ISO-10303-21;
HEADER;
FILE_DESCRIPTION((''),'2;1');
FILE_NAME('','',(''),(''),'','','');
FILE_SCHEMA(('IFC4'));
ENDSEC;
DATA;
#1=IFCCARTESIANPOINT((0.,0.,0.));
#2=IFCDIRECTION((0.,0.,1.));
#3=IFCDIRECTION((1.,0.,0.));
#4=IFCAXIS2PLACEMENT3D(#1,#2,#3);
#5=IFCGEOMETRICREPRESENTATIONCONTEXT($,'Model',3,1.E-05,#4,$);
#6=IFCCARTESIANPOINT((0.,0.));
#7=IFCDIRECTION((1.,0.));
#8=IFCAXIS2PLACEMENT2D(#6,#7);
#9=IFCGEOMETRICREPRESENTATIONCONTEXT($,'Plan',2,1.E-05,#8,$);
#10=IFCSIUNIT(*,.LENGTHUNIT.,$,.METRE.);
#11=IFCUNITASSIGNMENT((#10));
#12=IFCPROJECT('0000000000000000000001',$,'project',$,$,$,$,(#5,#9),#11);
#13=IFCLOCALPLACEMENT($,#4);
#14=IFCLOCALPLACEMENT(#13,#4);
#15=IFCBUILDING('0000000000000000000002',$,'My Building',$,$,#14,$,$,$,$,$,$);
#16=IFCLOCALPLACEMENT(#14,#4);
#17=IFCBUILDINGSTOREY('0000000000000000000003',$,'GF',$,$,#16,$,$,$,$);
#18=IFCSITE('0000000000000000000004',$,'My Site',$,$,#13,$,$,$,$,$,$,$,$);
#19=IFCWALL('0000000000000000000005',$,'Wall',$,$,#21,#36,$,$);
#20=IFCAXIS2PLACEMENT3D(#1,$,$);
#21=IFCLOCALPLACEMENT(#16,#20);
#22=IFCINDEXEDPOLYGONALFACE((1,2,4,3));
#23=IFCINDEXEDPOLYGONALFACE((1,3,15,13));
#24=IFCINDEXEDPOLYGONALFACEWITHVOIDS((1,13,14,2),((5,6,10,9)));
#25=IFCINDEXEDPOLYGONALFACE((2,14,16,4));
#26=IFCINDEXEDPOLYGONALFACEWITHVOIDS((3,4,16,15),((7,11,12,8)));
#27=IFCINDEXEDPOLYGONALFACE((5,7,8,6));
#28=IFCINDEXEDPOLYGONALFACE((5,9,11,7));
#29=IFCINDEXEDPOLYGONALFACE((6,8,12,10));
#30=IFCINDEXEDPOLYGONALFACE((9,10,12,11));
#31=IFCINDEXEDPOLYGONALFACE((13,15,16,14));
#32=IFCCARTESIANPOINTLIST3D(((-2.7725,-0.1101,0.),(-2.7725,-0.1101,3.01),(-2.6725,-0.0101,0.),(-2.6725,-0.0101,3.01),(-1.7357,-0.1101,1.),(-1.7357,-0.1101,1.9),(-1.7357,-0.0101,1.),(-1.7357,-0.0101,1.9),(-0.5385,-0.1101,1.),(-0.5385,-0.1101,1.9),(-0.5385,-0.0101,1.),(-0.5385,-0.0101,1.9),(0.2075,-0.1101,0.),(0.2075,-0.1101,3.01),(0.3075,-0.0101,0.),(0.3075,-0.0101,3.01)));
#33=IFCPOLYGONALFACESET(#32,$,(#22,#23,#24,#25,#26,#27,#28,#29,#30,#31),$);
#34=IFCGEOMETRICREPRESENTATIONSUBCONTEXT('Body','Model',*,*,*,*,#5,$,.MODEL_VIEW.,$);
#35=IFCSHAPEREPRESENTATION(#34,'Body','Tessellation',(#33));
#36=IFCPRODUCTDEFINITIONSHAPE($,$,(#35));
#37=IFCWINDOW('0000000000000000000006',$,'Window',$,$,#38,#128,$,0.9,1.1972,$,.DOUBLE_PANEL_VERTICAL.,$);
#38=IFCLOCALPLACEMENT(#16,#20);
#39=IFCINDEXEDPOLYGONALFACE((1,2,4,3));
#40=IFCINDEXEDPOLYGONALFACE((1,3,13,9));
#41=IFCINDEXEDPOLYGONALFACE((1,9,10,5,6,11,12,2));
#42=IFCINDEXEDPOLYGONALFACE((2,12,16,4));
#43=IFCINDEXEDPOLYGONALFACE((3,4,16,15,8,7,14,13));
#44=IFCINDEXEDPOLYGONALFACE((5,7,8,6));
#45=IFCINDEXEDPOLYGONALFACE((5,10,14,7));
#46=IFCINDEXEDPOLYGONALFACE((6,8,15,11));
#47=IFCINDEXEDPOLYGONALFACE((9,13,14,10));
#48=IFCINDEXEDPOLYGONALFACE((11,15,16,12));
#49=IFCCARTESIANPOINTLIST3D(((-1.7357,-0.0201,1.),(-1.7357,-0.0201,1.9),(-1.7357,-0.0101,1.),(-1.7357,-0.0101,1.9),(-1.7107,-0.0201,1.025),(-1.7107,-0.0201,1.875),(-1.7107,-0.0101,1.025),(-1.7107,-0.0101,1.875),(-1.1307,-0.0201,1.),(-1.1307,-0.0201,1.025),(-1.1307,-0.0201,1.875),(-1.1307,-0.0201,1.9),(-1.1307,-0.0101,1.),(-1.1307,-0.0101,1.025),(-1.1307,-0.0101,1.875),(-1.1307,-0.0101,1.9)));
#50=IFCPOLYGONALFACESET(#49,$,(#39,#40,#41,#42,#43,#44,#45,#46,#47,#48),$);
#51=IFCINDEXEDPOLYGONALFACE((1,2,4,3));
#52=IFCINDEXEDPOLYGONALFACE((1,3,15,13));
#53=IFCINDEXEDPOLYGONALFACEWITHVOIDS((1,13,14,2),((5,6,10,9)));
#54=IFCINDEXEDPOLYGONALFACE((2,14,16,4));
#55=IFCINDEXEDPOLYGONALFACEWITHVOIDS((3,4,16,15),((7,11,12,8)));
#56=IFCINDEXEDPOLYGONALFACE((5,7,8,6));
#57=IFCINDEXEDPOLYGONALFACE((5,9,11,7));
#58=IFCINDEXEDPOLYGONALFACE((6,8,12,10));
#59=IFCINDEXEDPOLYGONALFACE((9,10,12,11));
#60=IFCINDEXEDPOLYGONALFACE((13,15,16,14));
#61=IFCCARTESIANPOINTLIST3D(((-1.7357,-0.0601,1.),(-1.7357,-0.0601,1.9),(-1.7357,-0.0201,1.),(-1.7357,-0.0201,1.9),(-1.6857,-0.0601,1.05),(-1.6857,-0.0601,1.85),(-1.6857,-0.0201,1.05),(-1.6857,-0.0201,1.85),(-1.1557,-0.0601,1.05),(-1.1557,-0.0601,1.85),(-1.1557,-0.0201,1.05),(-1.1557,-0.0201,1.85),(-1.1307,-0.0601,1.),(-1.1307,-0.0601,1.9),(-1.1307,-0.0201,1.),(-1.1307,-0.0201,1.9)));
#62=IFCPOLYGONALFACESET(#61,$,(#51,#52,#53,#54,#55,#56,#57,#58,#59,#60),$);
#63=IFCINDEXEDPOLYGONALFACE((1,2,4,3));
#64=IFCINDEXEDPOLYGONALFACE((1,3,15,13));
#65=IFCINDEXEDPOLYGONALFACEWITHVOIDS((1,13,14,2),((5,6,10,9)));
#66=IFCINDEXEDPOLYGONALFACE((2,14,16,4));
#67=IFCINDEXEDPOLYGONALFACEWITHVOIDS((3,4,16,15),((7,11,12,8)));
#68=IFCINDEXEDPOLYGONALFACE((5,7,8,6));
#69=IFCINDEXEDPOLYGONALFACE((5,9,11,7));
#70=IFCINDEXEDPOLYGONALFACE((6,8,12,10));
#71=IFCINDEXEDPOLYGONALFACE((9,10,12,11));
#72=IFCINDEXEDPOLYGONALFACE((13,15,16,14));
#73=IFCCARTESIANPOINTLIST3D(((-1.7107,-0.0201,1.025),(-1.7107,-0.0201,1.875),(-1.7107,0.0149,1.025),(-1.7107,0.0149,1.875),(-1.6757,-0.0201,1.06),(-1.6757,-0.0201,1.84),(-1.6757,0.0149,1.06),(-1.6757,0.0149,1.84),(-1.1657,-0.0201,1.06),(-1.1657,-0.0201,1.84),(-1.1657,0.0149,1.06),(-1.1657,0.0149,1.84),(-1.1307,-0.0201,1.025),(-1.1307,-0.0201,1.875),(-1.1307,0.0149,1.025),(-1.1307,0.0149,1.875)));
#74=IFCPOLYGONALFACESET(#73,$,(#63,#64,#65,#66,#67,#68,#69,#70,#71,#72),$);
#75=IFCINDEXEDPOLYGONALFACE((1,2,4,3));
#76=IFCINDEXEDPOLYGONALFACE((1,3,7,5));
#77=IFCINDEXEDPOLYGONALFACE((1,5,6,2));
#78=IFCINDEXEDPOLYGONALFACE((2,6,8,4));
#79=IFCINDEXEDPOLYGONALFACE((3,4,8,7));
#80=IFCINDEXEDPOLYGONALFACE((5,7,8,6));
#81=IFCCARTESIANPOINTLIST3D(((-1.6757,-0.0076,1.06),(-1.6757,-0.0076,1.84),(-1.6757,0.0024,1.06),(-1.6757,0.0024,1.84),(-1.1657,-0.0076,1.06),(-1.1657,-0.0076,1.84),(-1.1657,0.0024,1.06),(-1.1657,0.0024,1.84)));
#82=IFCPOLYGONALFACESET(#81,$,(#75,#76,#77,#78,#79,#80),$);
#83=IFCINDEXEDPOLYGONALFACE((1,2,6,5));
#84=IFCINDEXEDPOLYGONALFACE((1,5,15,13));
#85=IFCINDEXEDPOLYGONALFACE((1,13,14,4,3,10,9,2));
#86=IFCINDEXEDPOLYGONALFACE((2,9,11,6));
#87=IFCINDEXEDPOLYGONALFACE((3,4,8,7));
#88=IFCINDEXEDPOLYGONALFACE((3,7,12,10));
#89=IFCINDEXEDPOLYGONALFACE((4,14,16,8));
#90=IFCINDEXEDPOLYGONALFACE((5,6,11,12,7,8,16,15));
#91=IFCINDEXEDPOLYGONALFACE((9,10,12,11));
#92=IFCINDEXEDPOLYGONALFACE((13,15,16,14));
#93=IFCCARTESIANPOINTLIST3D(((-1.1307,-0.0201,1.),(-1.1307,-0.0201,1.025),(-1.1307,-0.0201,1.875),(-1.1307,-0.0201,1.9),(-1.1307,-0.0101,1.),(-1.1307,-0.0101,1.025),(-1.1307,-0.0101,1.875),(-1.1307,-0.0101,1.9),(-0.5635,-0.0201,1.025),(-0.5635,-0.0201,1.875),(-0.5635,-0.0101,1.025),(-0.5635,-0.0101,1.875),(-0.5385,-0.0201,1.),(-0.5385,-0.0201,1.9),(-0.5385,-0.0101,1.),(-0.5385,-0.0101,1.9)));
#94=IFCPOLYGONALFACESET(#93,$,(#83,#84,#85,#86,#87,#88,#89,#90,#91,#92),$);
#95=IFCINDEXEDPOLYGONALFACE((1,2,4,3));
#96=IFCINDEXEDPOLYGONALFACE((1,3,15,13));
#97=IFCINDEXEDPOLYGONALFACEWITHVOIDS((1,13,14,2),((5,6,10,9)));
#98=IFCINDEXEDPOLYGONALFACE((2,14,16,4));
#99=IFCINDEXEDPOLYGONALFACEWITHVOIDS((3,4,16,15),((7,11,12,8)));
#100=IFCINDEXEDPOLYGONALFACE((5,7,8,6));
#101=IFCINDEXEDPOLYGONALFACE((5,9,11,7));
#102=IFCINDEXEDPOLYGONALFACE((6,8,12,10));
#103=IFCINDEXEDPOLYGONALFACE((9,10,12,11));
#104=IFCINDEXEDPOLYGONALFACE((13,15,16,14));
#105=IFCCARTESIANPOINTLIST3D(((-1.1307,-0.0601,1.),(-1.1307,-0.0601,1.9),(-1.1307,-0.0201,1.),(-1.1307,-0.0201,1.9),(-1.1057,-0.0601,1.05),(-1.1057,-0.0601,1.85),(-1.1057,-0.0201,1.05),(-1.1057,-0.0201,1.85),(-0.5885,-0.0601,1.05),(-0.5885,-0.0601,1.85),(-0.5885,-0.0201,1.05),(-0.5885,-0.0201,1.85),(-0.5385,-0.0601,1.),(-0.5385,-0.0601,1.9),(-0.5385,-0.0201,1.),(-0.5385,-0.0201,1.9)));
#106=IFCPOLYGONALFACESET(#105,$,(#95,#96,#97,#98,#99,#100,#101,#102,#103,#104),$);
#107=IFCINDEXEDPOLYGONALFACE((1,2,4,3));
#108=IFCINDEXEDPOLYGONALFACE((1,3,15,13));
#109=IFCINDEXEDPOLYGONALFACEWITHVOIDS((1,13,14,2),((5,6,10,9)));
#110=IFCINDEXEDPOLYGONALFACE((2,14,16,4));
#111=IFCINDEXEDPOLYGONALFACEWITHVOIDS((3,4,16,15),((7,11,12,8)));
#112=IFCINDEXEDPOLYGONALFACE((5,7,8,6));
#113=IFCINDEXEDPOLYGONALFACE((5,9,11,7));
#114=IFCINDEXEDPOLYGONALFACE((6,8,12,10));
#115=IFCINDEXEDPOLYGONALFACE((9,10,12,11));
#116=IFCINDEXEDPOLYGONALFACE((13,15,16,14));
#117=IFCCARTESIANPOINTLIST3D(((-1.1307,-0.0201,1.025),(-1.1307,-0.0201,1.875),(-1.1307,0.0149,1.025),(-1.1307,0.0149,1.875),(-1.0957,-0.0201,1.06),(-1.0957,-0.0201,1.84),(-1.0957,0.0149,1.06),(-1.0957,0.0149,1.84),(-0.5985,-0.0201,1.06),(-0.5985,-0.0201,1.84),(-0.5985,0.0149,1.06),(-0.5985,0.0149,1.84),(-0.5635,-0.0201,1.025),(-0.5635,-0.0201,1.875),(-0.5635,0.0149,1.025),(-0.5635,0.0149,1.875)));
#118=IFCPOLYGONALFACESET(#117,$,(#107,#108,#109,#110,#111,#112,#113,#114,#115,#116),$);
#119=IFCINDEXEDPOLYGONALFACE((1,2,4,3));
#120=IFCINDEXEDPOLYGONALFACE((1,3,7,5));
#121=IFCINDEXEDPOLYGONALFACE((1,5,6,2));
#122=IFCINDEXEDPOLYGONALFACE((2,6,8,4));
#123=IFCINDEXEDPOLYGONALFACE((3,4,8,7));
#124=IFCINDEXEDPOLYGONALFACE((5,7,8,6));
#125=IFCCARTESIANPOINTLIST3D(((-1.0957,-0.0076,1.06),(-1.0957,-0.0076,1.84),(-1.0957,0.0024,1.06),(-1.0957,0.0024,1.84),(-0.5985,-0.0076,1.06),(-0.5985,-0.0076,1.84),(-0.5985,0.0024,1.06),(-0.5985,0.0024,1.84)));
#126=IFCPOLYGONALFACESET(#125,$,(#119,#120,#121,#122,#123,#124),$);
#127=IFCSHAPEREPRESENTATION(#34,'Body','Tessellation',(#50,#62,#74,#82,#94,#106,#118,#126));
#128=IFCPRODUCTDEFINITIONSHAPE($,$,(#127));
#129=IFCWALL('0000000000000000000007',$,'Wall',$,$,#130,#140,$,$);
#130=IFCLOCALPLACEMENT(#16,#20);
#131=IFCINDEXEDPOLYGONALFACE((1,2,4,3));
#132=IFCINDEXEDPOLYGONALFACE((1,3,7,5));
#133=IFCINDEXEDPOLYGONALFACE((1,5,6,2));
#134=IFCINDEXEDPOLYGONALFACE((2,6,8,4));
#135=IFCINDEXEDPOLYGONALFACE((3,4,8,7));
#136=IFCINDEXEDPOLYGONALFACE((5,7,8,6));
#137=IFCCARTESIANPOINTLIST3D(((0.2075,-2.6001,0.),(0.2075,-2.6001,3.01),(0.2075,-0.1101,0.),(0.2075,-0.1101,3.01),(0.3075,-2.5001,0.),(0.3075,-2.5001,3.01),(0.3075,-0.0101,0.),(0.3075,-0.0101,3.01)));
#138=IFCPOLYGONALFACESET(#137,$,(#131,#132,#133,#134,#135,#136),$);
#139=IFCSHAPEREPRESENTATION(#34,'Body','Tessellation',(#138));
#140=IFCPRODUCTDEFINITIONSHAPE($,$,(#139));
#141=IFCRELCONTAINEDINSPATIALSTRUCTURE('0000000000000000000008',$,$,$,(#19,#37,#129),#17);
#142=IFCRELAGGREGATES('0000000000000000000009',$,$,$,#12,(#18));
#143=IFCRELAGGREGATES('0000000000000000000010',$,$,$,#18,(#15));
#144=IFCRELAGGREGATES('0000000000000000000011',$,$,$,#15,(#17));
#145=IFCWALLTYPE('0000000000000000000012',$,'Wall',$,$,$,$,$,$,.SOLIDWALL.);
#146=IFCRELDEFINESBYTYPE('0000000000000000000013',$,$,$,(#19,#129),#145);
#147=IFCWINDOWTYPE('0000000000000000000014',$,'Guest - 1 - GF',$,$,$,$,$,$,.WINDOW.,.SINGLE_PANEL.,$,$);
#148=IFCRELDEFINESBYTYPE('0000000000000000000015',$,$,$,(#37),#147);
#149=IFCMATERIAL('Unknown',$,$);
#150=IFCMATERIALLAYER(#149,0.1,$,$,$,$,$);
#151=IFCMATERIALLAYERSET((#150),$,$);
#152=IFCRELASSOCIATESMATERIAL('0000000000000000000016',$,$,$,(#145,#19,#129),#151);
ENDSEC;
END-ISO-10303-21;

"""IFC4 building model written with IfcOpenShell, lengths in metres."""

from ifc_helpers import new_model, entity, si_unit, frame, origin_with_axes, origin_2d_with_axis, place, context, subcontext, project, spatial, line, indexed_curve, outline, extrude, shape, source, transform, mapped, material, layer, layer_set, layer_usage, type_object, type_shapes, element, fill, save


model = new_model("IFC4")

# Units and contexts
model_context = context("Model", 3, precision=1e-05, world=origin_with_axes())
plan_context = context("Plan", 2, precision=1e-05, world=origin_2d_with_axis())
body_context_1 = subcontext(model_context, "Body", "Model", "MODEL_VIEW")
body_context_2 = subcontext(plan_context, "Body", "Plan", "PLAN_VIEW")
ifc_project = project(units=[si_unit("LENGTHUNIT", "METRE")], contexts=[model_context, plan_context])

# Site, building, storey
site_placement = place(None, origin_with_axes())
site = spatial("IfcSite", under=ifc_project, at=site_placement, Name="My Site")
building_placement = place(site_placement, origin_with_axes())
building = spatial("IfcBuilding", under=site, at=building_placement, Name="My Building")
storey_placement = place(building_placement, origin_with_axes())
storey = spatial("IfcBuildingStorey", under=building, at=storey_placement, Name="GF")

# Shared definitions
ifc_material = material(Name="Unknown")

# Shared definitions
ifc_layer_1 = layer(ifc_material, 0.1)
ifc_layer_set_1 = layer_set([ifc_layer_1])
wall_type = type_object("IfcWallType", Name="Wall", PredefinedType="SOLIDWALL", material=ifc_layer_set_1)

# Wall, opening, window
ifc_layer_usage_1 = layer_usage(ifc_layer_set_1, "AXIS2", "POSITIVE", 0.0)
wall_1_placement = place(storey_placement, frame((-2.7725, -0.1101, 0.0), z_axis=(0.0, 0.0, 1.0), x_axis=(1.0, 0.0, 0.0)))
wall_1 = element("IfcWall", 1, at=wall_1_placement, inside=storey, type_object=wall_type, material=ifc_layer_usage_1, Name="Wall", context=body_context_1, shape_type="SweptSolid", body=[
    extrude(outline(indexed_curve([(0.0, 0.0), (0.1, 0.1), (3.08, 0.1), (2.98, 0.0)], segments=[line(1, 2, 3, 4, 1)])), origin_with_axes(), (0.0, 0.0, 1.0), 3.01),
])
shared_shape_1 = source(origin_with_axes(), body_context_1, "Body", "SweptSolid", [
    extrude(outline(indexed_curve([(0.0, 0.0), (1.1972, 0.0), (1.1972, 0.9), (0.0, 0.9)], segments=[line(1, 2, 3, 4, 1)])), frame((0.0, -0.6, 0.0), z_axis=(0.0, -1.0, 0.0), x_axis=(1.0, 0.0, 0.0)), (0.0, 0.0, -1.0), 1.2),
])
opening_1_placement = place(wall_1_placement, frame((1.0369, 0.0, 1.0), z_axis=(0.0, 0.0, 1.0), x_axis=(1.0, 0.0, 0.0)))
opening_1 = element("IfcOpeningElement", 2, at=opening_1_placement, cuts=wall_1, PredefinedType="OPENING", context=body_context_1, shape_type="MappedRepresentation", body=[
    mapped(shared_shape_1, transform((0.0, 0.0, 0.0), x_axis=(1.0, 0.0, 0.0), y_axis=(0.0, 1.0, 0.0), z_axis=(0.0, 0.0, 1.0), scale=1.0)),
])
window_type_1 = type_object("IfcWindowType", Name="Guest - 1 - GF", PartitioningType="SINGLE_PANEL", PredefinedType="WINDOW")
shared_shape_2 = source(origin_with_axes(), body_context_1, "Body", "SweptSolid", [
    extrude(outline(indexed_curve([(0.605, 0.0), (0.0, 0.0), (0.0, 0.9), (0.605, 0.9), (0.605, 0.875), (0.025, 0.875), (0.025, 0.025), (0.605, 0.025)], segments=[line(1, 2, 3, 4, 5, 6, 7, 8, 1)])), frame((0.0, 0.09, 0.0), z_axis=(0.0, -1.0, 0.0), x_axis=(1.0, 0.0, 0.0)), (0.0, 0.0, -1.0), 0.01),
    extrude(outline(indexed_curve([(0.0, 0.0), (0.605, 0.0), (0.605, 0.9), (0.0, 0.9)], segments=[line(1, 2, 3, 4, 1)]), holes=[indexed_curve([(0.05, 0.05), (0.58, 0.05), (0.58, 0.85), (0.05, 0.85)], segments=[line(1, 2, 3, 4, 1)])]), frame((0.0, 0.05, 0.0), z_axis=(0.0, -1.0, 0.0), x_axis=(1.0, 0.0, 0.0)), (0.0, 0.0, -1.0), 0.04),
    extrude(outline(indexed_curve([(0.0, 0.0), (0.58, 0.0), (0.58, 0.85), (0.0, 0.85)], segments=[line(1, 2, 3, 4, 1)]), holes=[indexed_curve([(0.035, 0.035), (0.545, 0.035), (0.545, 0.815), (0.035, 0.815)], segments=[line(1, 2, 3, 4, 1)])]), frame((0.025, 0.09, 0.025), z_axis=(0.0, -1.0, 0.0), x_axis=(1.0, 0.0, 0.0)), (0.0, 0.0, -1.0), 0.035),
    extrude(outline(indexed_curve([(0.035, 0.035), (0.545, 0.035), (0.545, 0.815), (0.035, 0.815)], segments=[line(1, 2, 3, 4, 1)])), frame((0.025, 0.1025, 0.025), z_axis=(0.0, -1.0, 0.0), x_axis=(1.0, 0.0, 0.0)), (0.0, 0.0, -1.0), 0.01),
    extrude(outline(indexed_curve([(0.0, 0.9), (0.5922, 0.9), (0.5922, 0.0), (0.0, 0.0), (0.0, 0.025), (0.5672, 0.025), (0.5672, 0.875), (0.0, 0.875)], segments=[line(1, 2, 3, 4, 5, 6, 7, 8, 1)])), frame((0.605, 0.09, 0.0), z_axis=(0.0, -1.0, 0.0), x_axis=(1.0, 0.0, 0.0)), (0.0, 0.0, -1.0), 0.01),
    extrude(outline(indexed_curve([(0.0, 0.0), (0.5922, 0.0), (0.5922, 0.9), (0.0, 0.9)], segments=[line(1, 2, 3, 4, 1)]), holes=[indexed_curve([(0.025, 0.05), (0.5422, 0.05), (0.5422, 0.85), (0.025, 0.85)], segments=[line(1, 2, 3, 4, 1)])]), frame((0.605, 0.05, 0.0), z_axis=(0.0, -1.0, 0.0), x_axis=(1.0, 0.0, 0.0)), (0.0, 0.0, -1.0), 0.04),
    extrude(outline(indexed_curve([(0.0, 0.0), (0.5672, 0.0), (0.5672, 0.85), (0.0, 0.85)], segments=[line(1, 2, 3, 4, 1)]), holes=[indexed_curve([(0.035, 0.035), (0.5322, 0.035), (0.5322, 0.815), (0.035, 0.815)], segments=[line(1, 2, 3, 4, 1)])]), frame((0.605, 0.09, 0.025), z_axis=(0.0, -1.0, 0.0), x_axis=(1.0, 0.0, 0.0)), (0.0, 0.0, -1.0), 0.035),
    extrude(outline(indexed_curve([(0.035, 0.035), (0.5322, 0.035), (0.5322, 0.815), (0.035, 0.815)], segments=[line(1, 2, 3, 4, 1)])), frame((0.605, 0.1025, 0.025), z_axis=(0.0, -1.0, 0.0), x_axis=(1.0, 0.0, 0.0)), (0.0, 0.0, -1.0), 0.01),
])
shared_shape_3 = source(origin_with_axes(), body_context_2, "Body", "Curve2D", [
    entity("IfcIndexedPolyCurve", entity("IfcCartesianPointList2D", [[0.05, 0.05], [0.58, 0.05]])),
    entity("IfcIndexedPolyCurve", entity("IfcCartesianPointList2D", [[0.0, 0.1], [0.025, 0.1], [0.025, 0.09], [0.05, 0.09], [0.05, 0.05], [0.0, 0.05]]), [entity("IfcLineIndex", [1, 2, 3, 4, 5, 6, 1])]),
    entity("IfcIndexedPolyCurve", entity("IfcCartesianPointList2D", [[0.605, 0.1], [0.605, 0.1], [0.605, 0.09], [0.58, 0.09], [0.58, 0.05], [0.605, 0.05]])),
    entity("IfcIndexedPolyCurve", entity("IfcCartesianPointList2D", [[0.025, 0.09], [0.06, 0.09], [0.06, 0.125], [0.025, 0.125]]), [entity("IfcLineIndex", [1, 2, 3, 4, 1])]),
    entity("IfcIndexedPolyCurve", entity("IfcCartesianPointList2D", [[0.605, 0.09], [0.57, 0.09], [0.57, 0.125], [0.605, 0.125]]), [entity("IfcLineIndex", [1, 2, 3, 4, 1])]),
    entity("IfcIndexedPolyCurve", entity("IfcCartesianPointList2D", [[0.06, 0.09], [0.57, 0.09]])),
    entity("IfcIndexedPolyCurve", entity("IfcCartesianPointList2D", [[0.06, 0.125], [0.57, 0.125]])),
    entity("IfcIndexedPolyCurve", entity("IfcCartesianPointList2D", [[0.06, 0.1075], [0.57, 0.1075]])),
    entity("IfcIndexedPolyCurve", entity("IfcCartesianPointList2D", [[0.63, 0.05], [1.1472, 0.05]])),
    entity("IfcIndexedPolyCurve", entity("IfcCartesianPointList2D", [[0.605, 0.1], [0.605, 0.1], [0.605, 0.09], [0.63, 0.09], [0.63, 0.05], [0.605, 0.05]])),
    entity("IfcIndexedPolyCurve", entity("IfcCartesianPointList2D", [[1.1972, 0.1], [1.1722, 0.1], [1.1722, 0.09], [1.1472, 0.09], [1.1472, 0.05], [1.1972, 0.05]]), [entity("IfcLineIndex", [1, 2, 3, 4, 5, 6, 1])]),
    entity("IfcIndexedPolyCurve", entity("IfcCartesianPointList2D", [[0.605, 0.09], [0.64, 0.09], [0.64, 0.125], [0.605, 0.125]]), [entity("IfcLineIndex", [1, 2, 3, 4, 1])]),
    entity("IfcIndexedPolyCurve", entity("IfcCartesianPointList2D", [[1.1722, 0.09], [1.1372, 0.09], [1.1372, 0.125], [1.1722, 0.125]]), [entity("IfcLineIndex", [1, 2, 3, 4, 1])]),
    entity("IfcIndexedPolyCurve", entity("IfcCartesianPointList2D", [[0.64, 0.09], [1.1372, 0.09]])),
    entity("IfcIndexedPolyCurve", entity("IfcCartesianPointList2D", [[0.64, 0.125], [1.1372, 0.125]])),
    entity("IfcIndexedPolyCurve", entity("IfcCartesianPointList2D", [[0.64, 0.1075], [1.1372, 0.1075]])),
])
type_shapes(window_type_1, [shared_shape_2, shared_shape_3])
window_1_placement = place(opening_1_placement, origin_with_axes())
window_1 = element("IfcWindow", 3, at=window_1_placement, inside=storey, type_object=window_type_1, Name="Window", OverallHeight=0.9, OverallWidth=1.1972, PartitioningType="DOUBLE_PANEL_VERTICAL", shapes=[
    shape(body_context_1, "Body", "MappedRepresentation", [mapped(shared_shape_2, transform((0.0, 0.0, 0.0), x_axis=(1.0, 0.0, 0.0), y_axis=(0.0, 1.0, 0.0), z_axis=(0.0, 0.0, 1.0), scale=1.0))]),
    shape(body_context_2, "Body", "MappedRepresentation", [mapped(shared_shape_3, transform((0.0, 0.0, 0.0), x_axis=(1.0, 0.0, 0.0), y_axis=(0.0, 1.0, 0.0), z_axis=(0.0, 0.0, 1.0), scale=1.0))]),
])
fill(opening_1, window_1)

# Wall
ifc_layer_usage_2 = layer_usage(ifc_layer_set_1, "AXIS2", "POSITIVE", 0.0)
wall_2_placement = place(storey_placement, frame((0.2075, -0.1101, 0.0), z_axis=(0.0, 0.0, 1.0), x_axis=(0.0, -1.0, 0.0)))
element("IfcWall", 4, at=wall_2_placement, inside=storey, type_object=wall_type, material=ifc_layer_usage_2, Name="Wall", context=body_context_1, shape_type="SweptSolid", body=[
    extrude(outline(indexed_curve([(0.0, 0.0), (-0.1, 0.1), (2.39, 0.1), (2.49, 0.0)], segments=[line(1, 2, 3, 4, 1)])), origin_with_axes(), (0.0, 0.0, 1.0), 3.01),
])

save(model, "model.ifc")
